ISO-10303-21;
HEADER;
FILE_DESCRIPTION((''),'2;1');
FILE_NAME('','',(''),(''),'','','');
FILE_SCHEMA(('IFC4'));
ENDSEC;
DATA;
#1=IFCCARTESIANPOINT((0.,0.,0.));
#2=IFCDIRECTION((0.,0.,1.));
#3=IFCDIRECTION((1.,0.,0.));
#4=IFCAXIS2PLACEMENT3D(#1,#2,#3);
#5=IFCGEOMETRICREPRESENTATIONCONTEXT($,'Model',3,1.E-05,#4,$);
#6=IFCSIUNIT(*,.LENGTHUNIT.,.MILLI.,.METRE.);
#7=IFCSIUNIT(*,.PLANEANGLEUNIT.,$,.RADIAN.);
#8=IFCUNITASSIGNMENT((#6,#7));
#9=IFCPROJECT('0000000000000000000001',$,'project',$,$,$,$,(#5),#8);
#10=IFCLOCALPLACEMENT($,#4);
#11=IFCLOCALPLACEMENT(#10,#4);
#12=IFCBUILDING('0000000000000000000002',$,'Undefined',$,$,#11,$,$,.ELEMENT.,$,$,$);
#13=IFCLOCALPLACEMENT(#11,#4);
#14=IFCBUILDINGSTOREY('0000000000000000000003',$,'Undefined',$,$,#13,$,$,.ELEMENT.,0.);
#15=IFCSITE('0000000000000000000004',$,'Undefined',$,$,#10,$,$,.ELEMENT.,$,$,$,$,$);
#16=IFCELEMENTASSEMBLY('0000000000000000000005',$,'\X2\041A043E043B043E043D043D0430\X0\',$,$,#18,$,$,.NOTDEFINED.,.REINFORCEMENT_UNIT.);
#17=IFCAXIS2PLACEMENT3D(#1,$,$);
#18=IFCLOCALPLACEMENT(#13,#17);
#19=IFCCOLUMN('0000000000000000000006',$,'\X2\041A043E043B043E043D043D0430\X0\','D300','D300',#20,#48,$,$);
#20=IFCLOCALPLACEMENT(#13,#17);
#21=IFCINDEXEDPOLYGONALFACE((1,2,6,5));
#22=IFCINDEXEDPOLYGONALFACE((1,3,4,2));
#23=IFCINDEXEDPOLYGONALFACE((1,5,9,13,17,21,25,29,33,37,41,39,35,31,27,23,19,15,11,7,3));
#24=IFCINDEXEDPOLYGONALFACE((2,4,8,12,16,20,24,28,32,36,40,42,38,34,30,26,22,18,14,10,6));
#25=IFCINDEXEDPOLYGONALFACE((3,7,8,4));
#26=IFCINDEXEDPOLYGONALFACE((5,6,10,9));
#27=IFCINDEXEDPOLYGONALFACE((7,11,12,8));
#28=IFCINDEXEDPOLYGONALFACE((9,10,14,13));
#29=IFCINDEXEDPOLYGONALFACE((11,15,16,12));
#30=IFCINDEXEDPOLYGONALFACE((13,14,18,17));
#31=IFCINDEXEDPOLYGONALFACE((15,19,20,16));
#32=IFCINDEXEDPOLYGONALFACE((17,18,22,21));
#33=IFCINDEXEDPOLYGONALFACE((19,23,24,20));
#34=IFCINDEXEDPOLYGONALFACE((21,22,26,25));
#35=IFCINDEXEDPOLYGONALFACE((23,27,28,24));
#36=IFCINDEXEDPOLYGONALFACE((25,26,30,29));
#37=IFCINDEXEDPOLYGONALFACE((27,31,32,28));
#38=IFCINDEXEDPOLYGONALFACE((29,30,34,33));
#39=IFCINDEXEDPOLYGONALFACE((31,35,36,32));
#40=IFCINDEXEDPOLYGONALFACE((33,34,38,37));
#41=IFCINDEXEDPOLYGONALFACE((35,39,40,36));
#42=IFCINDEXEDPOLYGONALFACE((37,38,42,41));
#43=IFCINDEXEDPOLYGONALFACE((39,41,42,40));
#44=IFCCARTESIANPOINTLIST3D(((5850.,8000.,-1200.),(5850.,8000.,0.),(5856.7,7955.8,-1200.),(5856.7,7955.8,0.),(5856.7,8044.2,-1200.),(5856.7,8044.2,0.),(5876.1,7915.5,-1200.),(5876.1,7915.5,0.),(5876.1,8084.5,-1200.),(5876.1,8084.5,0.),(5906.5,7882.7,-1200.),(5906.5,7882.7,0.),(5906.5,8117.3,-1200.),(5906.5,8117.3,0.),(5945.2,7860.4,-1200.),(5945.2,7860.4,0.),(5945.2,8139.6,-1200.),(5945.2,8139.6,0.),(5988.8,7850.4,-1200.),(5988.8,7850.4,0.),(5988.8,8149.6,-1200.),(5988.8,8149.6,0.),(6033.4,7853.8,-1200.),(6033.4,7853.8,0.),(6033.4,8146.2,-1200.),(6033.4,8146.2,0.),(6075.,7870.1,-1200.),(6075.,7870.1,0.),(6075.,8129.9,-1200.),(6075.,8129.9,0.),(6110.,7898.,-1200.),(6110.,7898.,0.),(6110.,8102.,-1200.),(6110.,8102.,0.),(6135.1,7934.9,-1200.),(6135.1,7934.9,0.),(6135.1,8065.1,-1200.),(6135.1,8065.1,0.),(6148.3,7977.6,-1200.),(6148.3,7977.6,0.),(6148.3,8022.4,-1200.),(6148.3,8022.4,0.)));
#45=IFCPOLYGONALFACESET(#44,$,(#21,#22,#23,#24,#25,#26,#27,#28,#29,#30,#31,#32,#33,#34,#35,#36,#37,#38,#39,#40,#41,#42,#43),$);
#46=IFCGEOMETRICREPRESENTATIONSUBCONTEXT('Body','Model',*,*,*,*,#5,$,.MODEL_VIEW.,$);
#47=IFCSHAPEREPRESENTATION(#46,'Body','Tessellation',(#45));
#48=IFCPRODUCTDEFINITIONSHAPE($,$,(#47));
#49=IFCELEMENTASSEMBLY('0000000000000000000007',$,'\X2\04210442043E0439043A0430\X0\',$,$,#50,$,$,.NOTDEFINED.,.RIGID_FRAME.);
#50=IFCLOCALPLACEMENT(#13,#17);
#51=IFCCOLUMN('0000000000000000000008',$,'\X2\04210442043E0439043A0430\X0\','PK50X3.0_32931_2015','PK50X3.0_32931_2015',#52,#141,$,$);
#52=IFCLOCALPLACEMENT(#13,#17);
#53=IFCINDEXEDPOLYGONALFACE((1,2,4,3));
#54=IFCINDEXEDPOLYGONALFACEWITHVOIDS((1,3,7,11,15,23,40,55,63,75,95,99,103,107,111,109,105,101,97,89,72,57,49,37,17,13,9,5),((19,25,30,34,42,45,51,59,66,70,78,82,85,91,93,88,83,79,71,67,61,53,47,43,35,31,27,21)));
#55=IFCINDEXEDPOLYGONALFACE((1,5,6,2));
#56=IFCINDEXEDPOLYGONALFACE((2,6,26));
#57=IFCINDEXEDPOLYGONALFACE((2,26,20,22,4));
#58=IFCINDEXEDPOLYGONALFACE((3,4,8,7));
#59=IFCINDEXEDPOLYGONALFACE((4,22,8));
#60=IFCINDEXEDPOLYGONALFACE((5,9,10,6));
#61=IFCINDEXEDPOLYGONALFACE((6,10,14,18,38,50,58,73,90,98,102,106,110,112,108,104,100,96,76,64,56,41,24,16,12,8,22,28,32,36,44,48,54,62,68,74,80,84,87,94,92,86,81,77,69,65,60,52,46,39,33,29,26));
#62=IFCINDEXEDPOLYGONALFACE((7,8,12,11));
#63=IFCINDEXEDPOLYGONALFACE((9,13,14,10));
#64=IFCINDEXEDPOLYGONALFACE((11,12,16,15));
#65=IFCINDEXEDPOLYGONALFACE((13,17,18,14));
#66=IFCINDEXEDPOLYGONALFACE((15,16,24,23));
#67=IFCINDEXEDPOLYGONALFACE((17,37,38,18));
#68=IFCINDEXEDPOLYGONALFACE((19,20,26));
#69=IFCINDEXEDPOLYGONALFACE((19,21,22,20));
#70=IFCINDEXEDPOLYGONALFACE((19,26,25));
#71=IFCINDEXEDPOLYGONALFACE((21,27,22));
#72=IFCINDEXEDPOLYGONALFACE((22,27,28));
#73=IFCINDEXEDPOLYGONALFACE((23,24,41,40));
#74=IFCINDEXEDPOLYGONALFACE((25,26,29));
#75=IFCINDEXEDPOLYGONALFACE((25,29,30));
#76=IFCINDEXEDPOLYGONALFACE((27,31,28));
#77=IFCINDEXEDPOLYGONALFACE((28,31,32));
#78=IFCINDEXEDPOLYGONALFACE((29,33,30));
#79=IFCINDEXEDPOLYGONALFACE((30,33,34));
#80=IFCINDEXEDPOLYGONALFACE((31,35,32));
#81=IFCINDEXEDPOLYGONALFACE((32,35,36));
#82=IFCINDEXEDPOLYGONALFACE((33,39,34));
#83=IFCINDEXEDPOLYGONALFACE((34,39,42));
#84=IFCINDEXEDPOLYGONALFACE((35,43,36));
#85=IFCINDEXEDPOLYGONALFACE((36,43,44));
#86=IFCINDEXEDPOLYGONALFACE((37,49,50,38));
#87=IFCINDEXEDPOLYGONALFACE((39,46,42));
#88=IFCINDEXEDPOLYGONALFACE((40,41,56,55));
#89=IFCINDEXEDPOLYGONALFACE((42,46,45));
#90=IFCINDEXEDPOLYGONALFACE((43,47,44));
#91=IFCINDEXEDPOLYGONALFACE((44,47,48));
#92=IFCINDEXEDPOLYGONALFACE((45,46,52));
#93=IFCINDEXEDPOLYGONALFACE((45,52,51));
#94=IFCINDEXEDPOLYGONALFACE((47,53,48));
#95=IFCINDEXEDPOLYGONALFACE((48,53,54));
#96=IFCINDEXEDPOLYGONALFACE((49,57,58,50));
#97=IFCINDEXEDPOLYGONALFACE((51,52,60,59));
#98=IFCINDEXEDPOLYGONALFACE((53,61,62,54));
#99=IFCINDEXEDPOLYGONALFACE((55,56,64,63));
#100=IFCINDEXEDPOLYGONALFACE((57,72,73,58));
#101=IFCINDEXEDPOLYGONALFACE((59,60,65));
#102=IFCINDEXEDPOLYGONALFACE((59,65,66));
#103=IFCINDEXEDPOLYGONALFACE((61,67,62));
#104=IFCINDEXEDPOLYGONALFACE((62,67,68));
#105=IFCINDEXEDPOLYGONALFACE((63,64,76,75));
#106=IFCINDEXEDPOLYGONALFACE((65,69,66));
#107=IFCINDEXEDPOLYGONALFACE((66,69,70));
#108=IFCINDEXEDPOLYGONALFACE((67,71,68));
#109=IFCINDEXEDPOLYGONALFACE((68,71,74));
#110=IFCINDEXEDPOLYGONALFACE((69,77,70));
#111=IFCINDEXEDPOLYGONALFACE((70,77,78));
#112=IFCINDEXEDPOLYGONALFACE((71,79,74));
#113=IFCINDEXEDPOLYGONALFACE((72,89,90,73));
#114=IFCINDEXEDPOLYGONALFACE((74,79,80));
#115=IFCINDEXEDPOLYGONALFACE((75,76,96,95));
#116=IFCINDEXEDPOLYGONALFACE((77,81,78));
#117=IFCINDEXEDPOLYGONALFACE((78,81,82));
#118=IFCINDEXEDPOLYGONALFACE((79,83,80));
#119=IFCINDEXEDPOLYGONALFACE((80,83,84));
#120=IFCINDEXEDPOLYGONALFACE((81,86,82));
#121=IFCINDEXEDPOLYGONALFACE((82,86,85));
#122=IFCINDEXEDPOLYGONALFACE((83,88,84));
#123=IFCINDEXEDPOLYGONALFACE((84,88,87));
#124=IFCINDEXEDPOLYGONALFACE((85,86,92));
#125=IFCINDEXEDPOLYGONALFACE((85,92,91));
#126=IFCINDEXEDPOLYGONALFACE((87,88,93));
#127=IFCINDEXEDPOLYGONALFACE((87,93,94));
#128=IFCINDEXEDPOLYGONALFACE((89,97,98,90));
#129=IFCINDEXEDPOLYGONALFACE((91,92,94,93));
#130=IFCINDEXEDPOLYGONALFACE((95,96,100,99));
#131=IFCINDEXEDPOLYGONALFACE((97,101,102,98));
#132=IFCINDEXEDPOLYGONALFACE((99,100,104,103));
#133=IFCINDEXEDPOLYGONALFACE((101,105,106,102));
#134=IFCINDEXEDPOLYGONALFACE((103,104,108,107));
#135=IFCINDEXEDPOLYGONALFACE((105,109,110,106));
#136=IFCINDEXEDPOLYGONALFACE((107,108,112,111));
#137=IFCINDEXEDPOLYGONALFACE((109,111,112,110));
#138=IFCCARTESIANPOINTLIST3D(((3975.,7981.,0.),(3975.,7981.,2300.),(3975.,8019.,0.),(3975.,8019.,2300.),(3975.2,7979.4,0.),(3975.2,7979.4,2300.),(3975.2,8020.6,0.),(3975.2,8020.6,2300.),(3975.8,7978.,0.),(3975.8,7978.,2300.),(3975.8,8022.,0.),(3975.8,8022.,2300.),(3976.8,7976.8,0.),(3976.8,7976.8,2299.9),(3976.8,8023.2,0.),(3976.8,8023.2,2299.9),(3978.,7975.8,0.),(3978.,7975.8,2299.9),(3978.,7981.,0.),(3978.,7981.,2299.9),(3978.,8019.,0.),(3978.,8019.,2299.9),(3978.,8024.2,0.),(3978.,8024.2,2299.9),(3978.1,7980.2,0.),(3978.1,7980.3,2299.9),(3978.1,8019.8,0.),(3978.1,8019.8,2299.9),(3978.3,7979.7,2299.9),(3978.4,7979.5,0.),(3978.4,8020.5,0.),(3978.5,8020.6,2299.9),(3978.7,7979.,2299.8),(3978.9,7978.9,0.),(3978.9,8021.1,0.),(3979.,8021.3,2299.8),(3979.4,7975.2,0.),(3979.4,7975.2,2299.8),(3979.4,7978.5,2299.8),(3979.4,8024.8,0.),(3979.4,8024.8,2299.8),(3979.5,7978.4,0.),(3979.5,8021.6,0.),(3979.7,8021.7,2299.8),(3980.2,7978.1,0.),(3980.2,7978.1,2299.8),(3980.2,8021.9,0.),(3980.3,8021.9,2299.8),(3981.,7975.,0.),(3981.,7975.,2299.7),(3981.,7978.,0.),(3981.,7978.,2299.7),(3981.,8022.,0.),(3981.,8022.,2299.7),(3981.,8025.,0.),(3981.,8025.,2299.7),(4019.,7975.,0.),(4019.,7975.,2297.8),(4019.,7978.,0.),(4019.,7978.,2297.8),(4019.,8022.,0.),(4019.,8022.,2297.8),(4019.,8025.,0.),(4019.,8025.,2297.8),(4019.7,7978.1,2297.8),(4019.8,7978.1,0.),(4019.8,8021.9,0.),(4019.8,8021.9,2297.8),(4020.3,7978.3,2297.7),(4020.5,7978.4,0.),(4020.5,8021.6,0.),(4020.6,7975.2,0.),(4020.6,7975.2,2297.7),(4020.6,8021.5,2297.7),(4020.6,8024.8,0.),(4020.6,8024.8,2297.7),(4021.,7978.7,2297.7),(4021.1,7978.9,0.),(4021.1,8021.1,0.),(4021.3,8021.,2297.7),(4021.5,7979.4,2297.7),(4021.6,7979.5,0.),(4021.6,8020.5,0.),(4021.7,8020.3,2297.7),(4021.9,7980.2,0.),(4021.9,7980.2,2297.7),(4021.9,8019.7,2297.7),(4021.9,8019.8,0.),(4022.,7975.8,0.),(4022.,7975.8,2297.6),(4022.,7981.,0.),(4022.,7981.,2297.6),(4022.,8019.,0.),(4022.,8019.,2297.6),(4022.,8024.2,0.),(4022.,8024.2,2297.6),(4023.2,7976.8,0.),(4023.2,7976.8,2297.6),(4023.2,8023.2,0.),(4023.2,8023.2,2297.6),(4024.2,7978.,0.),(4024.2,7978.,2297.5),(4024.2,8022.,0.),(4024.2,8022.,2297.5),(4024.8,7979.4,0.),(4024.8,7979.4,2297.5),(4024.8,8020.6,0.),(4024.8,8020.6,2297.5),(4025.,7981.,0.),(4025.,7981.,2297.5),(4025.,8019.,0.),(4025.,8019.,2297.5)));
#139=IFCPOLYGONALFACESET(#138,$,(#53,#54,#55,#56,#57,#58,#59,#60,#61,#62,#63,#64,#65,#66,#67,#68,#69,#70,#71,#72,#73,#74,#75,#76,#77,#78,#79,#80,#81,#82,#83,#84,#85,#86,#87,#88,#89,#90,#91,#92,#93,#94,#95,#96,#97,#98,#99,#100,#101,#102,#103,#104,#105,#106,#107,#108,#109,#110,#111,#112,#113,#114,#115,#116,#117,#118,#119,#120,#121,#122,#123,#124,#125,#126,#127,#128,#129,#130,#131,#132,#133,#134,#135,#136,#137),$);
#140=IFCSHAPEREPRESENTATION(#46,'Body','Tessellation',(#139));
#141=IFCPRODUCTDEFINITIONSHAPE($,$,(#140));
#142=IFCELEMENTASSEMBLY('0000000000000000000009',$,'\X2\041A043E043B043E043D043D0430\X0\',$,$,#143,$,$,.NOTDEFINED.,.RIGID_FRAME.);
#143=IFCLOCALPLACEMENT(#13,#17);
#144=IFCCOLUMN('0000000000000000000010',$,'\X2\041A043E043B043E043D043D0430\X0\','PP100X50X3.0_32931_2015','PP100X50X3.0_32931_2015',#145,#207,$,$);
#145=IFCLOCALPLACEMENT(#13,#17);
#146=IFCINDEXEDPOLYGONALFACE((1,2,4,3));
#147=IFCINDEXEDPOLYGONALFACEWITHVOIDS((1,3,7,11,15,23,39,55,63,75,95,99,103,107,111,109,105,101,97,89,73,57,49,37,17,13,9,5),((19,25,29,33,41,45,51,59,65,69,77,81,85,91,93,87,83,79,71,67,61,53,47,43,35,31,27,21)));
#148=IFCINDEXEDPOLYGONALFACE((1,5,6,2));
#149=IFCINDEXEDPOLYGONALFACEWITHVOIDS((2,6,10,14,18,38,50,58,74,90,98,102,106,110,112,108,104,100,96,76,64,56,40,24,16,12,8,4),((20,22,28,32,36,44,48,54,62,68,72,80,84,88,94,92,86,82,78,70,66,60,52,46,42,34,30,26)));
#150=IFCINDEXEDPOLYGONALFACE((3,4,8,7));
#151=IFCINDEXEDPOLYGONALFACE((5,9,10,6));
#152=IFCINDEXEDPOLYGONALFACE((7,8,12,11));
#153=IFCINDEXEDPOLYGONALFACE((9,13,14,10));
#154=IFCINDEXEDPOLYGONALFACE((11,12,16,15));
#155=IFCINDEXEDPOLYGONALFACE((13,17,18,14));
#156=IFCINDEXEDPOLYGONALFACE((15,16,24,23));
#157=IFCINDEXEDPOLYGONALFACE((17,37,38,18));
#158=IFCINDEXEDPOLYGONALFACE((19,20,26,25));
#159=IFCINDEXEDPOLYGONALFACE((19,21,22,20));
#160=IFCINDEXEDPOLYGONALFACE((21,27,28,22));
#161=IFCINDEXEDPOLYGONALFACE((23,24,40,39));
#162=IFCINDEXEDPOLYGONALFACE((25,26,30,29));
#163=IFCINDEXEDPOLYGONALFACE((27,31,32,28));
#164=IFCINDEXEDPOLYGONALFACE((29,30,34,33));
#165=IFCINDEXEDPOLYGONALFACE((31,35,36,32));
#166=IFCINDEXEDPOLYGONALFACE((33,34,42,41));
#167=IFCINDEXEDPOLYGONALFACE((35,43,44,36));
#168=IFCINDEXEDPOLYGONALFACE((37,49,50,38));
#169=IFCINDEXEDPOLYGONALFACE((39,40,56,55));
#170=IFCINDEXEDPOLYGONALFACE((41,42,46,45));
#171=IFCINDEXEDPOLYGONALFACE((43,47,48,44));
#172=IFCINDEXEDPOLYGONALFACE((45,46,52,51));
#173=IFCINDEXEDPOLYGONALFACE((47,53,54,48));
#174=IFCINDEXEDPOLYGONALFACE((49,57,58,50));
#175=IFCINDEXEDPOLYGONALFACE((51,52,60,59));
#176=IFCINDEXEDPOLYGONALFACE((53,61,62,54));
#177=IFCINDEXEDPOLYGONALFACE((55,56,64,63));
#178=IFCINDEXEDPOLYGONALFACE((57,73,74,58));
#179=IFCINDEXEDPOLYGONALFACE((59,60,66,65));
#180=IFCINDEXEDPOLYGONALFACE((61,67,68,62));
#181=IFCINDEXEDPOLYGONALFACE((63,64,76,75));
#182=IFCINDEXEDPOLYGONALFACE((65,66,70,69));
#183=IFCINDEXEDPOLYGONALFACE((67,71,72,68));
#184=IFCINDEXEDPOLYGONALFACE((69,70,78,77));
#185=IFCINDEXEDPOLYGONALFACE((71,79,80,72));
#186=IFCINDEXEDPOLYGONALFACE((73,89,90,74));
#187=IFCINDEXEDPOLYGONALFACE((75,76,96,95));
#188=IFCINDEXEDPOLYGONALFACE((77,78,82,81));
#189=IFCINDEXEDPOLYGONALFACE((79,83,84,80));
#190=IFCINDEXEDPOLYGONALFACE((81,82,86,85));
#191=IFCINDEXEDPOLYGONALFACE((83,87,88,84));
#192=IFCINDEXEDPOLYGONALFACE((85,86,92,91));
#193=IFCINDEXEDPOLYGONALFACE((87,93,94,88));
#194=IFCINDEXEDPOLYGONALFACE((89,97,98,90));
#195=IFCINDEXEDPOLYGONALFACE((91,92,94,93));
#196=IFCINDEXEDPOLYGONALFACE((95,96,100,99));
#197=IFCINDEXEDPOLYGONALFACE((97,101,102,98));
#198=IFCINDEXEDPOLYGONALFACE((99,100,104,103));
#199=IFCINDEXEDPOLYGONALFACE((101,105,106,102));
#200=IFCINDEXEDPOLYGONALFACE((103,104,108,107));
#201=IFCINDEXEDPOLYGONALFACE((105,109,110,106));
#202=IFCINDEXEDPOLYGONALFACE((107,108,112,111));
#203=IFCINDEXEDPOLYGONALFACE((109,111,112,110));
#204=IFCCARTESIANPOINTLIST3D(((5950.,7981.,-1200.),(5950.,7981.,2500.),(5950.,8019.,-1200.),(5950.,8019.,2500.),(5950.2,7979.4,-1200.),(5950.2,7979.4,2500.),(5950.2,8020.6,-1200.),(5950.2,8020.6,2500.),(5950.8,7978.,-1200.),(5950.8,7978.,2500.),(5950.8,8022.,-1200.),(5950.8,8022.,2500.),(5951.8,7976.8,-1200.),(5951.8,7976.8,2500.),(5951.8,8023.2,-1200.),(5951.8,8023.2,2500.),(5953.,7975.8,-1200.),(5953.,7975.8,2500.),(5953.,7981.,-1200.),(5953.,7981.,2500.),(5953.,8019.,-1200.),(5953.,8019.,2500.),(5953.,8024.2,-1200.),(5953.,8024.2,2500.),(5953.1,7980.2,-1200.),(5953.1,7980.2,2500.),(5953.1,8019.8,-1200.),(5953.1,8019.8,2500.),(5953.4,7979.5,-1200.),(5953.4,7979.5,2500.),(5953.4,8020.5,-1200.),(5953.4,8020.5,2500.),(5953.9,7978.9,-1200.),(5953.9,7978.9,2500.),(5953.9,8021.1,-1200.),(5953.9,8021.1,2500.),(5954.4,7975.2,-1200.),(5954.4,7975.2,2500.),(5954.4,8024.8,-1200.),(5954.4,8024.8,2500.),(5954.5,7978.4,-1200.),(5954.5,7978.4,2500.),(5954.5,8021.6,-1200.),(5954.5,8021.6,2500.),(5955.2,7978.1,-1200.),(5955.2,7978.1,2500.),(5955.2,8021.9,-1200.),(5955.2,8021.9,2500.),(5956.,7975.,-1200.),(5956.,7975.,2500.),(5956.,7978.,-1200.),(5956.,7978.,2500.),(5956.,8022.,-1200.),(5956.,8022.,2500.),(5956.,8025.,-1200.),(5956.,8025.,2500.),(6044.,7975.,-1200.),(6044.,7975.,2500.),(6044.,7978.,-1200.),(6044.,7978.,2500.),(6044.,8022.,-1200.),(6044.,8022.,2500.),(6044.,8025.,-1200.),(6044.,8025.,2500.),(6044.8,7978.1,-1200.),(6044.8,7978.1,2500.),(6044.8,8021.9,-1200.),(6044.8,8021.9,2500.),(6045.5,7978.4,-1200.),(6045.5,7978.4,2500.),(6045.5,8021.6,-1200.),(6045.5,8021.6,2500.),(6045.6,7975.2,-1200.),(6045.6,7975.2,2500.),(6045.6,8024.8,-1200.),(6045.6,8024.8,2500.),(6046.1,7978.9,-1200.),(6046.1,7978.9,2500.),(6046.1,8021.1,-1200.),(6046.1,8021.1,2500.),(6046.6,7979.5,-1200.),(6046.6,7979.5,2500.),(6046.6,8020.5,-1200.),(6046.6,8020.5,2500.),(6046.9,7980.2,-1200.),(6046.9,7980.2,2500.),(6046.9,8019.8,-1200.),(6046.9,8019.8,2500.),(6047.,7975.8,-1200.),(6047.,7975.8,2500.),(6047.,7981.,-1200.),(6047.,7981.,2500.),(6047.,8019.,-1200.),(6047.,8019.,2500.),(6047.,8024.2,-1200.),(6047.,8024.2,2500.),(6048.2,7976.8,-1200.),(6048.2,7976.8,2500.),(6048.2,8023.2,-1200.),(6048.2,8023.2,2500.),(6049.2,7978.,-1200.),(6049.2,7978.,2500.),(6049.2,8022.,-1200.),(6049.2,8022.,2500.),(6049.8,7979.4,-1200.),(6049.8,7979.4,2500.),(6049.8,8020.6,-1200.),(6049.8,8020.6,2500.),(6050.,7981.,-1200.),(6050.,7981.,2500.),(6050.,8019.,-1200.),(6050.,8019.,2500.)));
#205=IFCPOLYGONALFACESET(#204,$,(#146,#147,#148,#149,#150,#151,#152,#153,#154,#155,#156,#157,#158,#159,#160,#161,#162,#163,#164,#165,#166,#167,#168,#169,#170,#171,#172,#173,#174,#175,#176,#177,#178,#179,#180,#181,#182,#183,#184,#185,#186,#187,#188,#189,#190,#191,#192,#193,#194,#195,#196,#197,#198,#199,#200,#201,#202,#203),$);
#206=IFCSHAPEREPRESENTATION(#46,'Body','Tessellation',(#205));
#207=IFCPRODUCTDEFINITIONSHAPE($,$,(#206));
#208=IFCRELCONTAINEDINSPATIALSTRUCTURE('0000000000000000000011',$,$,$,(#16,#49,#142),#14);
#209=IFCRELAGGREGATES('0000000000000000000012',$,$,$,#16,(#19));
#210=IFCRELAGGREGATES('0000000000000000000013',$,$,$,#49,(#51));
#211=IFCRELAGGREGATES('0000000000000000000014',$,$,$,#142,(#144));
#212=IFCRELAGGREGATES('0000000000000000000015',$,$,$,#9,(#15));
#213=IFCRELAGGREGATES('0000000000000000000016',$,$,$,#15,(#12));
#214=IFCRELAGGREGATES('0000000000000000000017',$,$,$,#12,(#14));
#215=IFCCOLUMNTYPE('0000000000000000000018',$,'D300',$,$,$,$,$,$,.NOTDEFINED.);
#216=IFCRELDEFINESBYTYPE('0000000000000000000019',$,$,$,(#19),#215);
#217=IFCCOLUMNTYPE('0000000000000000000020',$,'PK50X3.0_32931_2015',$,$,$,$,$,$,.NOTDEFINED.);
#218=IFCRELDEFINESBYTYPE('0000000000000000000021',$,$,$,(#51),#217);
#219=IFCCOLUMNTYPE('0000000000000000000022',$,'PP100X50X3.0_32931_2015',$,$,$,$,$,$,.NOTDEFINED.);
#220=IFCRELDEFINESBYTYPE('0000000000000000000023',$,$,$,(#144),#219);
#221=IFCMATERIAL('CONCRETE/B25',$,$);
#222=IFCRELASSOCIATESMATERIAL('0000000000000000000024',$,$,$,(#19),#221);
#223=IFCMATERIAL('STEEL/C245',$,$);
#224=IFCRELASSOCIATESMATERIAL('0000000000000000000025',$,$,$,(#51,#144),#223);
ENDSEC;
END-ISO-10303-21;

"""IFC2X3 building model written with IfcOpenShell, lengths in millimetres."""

from ifc_helpers import new_model, si_unit, frame, origin_with_axes, origin_2d_with_axis, place, context, subcontext, project, spatial, hollow_rectangle, circle, extrude, clip, halfspace, material, type_object, element, aggregate, save


model = new_model("IFC2X3")

# Units and contexts
model_context = context("Model", 3, precision=1e-05, world=origin_with_axes())
body_context = subcontext(model_context, "Body", "Model", "MODEL_VIEW")
ifc_project = project(units=[si_unit("LENGTHUNIT", "METRE", prefix="MILLI"), si_unit("PLANEANGLEUNIT", "RADIAN")], contexts=[model_context])

# Site, building, storey
site_placement = place(None, origin_with_axes())
site = spatial("IfcSite", under=ifc_project, at=site_placement, Name="Undefined", CompositionType="ELEMENT")
building_placement = place(site_placement, origin_with_axes())
building = spatial("IfcBuilding", under=site, at=building_placement, Name="Undefined", CompositionType="ELEMENT")
storey_placement = place(building_placement, origin_with_axes())
storey = spatial("IfcBuildingStorey", under=building, at=storey_placement, Name="Undefined", CompositionType="ELEMENT", Elevation=0.0)

# Element assemblies, columns
assembly_1_placement = place(storey_placement, origin_with_axes())
assembly_1 = element("IfcElementAssembly", 1, at=assembly_1_placement, inside=storey, Name="Колонна", AssemblyPlace="NOTDEFINED", PredefinedType="REINFORCEMENT_UNIT")
ifc_material_1 = material(Name="CONCRETE/B25")
column_type_1 = type_object("IfcColumnType", Name="D300", PredefinedType="NOTDEFINED")
column_1_placement = place(assembly_1_placement, frame((6000.0, 8000.0, -1200.0), z_axis=(0.0, 0.0, 1.0), x_axis=(0.0, 1.0, 0.0)))
column_1 = element("IfcColumn", 2, at=column_1_placement, type_object=column_type_1, material=ifc_material_1, Name="Колонна", Description="D300", ObjectType="D300", context=body_context, shape_type="SweptSolid", body=[
    extrude(circle(Radius=150.0, at=origin_2d_with_axis()), frame((0.0, 0.0, 1200.0), z_axis=(0.0, 0.0, -1.0), x_axis=(0.0, 1.0, 0.0)), (0.0, 0.0, 1.0), 1200.0),
])
aggregate(assembly_1, [column_1])
assembly_2_placement = place(storey_placement, origin_with_axes())
assembly_2 = element("IfcElementAssembly", 3, at=assembly_2_placement, inside=storey, Name="Стойка", AssemblyPlace="NOTDEFINED", PredefinedType="RIGID_FRAME")
ifc_material_2 = material(Name="STEEL/C245")
column_type_2 = type_object("IfcColumnType", Name="PK50X3.0_32931_2015", PredefinedType="NOTDEFINED")
column_2_placement = place(assembly_2_placement, frame((4000.0, 8000.0, 0.0), z_axis=(0.0, 0.0, 1.0), x_axis=(0.0, 1.0, 0.0)))
column_2 = element("IfcColumn", 4, at=column_2_placement, type_object=column_type_2, material=ifc_material_2, Name="Стойка", Description="PK50X3.0_32931_2015", ObjectType="PK50X3.0_32931_2015", context=body_context, shape_type="Clipping", body=[
    clip(extrude(hollow_rectangle(XDim=50.0, YDim=50.0, WallThickness=3.0, InnerFilletRadius=3.0, OuterFilletRadius=6.0, at=origin_2d_with_axis()), frame((0.0, 0.0, 2300.0), z_axis=(0.0, 0.0, -1.0), x_axis=(0.0, 1.0, 0.0)), (0.0, 0.0, 1.0), 2300.1), halfspace(frame((0.0, -147.1, 2291.3), z_axis=(0.0, 0.050782, -0.99871), x_axis=(-1.0, 0.0, 0.0)), True)),
])
aggregate(assembly_2, [column_2])
assembly_3_placement = place(storey_placement, origin_with_axes())
assembly_3 = element("IfcElementAssembly", 5, at=assembly_3_placement, inside=storey, Name="Колонна", AssemblyPlace="NOTDEFINED", PredefinedType="RIGID_FRAME")
column_type_3 = type_object("IfcColumnType", Name="PP100X50X3.0_32931_2015", PredefinedType="NOTDEFINED")
column_3_placement = place(assembly_3_placement, frame((6000.0, 8000.0, -1200.0), z_axis=(0.0, 0.0, 1.0), x_axis=(-1.0, 0.0, 0.0)))
column_3 = element("IfcColumn", 6, at=column_3_placement, type_object=column_type_3, material=ifc_material_2, Name="Колонна", Description="PP100X50X3.0_32931_2015", ObjectType="PP100X50X3.0_32931_2015", context=body_context, shape_type="SweptSolid", body=[
    extrude(hollow_rectangle(XDim=50.0, YDim=100.0, WallThickness=3.0, InnerFilletRadius=3.0, OuterFilletRadius=6.0, at=origin_2d_with_axis()), frame((0.0, 0.0, 3700.0), z_axis=(0.0, 0.0, -1.0), x_axis=(0.0, 1.0, 0.0)), (0.0, 0.0, 1.0), 3700.0),
])
aggregate(assembly_3, [column_3])

save(model, "model.ifc")
